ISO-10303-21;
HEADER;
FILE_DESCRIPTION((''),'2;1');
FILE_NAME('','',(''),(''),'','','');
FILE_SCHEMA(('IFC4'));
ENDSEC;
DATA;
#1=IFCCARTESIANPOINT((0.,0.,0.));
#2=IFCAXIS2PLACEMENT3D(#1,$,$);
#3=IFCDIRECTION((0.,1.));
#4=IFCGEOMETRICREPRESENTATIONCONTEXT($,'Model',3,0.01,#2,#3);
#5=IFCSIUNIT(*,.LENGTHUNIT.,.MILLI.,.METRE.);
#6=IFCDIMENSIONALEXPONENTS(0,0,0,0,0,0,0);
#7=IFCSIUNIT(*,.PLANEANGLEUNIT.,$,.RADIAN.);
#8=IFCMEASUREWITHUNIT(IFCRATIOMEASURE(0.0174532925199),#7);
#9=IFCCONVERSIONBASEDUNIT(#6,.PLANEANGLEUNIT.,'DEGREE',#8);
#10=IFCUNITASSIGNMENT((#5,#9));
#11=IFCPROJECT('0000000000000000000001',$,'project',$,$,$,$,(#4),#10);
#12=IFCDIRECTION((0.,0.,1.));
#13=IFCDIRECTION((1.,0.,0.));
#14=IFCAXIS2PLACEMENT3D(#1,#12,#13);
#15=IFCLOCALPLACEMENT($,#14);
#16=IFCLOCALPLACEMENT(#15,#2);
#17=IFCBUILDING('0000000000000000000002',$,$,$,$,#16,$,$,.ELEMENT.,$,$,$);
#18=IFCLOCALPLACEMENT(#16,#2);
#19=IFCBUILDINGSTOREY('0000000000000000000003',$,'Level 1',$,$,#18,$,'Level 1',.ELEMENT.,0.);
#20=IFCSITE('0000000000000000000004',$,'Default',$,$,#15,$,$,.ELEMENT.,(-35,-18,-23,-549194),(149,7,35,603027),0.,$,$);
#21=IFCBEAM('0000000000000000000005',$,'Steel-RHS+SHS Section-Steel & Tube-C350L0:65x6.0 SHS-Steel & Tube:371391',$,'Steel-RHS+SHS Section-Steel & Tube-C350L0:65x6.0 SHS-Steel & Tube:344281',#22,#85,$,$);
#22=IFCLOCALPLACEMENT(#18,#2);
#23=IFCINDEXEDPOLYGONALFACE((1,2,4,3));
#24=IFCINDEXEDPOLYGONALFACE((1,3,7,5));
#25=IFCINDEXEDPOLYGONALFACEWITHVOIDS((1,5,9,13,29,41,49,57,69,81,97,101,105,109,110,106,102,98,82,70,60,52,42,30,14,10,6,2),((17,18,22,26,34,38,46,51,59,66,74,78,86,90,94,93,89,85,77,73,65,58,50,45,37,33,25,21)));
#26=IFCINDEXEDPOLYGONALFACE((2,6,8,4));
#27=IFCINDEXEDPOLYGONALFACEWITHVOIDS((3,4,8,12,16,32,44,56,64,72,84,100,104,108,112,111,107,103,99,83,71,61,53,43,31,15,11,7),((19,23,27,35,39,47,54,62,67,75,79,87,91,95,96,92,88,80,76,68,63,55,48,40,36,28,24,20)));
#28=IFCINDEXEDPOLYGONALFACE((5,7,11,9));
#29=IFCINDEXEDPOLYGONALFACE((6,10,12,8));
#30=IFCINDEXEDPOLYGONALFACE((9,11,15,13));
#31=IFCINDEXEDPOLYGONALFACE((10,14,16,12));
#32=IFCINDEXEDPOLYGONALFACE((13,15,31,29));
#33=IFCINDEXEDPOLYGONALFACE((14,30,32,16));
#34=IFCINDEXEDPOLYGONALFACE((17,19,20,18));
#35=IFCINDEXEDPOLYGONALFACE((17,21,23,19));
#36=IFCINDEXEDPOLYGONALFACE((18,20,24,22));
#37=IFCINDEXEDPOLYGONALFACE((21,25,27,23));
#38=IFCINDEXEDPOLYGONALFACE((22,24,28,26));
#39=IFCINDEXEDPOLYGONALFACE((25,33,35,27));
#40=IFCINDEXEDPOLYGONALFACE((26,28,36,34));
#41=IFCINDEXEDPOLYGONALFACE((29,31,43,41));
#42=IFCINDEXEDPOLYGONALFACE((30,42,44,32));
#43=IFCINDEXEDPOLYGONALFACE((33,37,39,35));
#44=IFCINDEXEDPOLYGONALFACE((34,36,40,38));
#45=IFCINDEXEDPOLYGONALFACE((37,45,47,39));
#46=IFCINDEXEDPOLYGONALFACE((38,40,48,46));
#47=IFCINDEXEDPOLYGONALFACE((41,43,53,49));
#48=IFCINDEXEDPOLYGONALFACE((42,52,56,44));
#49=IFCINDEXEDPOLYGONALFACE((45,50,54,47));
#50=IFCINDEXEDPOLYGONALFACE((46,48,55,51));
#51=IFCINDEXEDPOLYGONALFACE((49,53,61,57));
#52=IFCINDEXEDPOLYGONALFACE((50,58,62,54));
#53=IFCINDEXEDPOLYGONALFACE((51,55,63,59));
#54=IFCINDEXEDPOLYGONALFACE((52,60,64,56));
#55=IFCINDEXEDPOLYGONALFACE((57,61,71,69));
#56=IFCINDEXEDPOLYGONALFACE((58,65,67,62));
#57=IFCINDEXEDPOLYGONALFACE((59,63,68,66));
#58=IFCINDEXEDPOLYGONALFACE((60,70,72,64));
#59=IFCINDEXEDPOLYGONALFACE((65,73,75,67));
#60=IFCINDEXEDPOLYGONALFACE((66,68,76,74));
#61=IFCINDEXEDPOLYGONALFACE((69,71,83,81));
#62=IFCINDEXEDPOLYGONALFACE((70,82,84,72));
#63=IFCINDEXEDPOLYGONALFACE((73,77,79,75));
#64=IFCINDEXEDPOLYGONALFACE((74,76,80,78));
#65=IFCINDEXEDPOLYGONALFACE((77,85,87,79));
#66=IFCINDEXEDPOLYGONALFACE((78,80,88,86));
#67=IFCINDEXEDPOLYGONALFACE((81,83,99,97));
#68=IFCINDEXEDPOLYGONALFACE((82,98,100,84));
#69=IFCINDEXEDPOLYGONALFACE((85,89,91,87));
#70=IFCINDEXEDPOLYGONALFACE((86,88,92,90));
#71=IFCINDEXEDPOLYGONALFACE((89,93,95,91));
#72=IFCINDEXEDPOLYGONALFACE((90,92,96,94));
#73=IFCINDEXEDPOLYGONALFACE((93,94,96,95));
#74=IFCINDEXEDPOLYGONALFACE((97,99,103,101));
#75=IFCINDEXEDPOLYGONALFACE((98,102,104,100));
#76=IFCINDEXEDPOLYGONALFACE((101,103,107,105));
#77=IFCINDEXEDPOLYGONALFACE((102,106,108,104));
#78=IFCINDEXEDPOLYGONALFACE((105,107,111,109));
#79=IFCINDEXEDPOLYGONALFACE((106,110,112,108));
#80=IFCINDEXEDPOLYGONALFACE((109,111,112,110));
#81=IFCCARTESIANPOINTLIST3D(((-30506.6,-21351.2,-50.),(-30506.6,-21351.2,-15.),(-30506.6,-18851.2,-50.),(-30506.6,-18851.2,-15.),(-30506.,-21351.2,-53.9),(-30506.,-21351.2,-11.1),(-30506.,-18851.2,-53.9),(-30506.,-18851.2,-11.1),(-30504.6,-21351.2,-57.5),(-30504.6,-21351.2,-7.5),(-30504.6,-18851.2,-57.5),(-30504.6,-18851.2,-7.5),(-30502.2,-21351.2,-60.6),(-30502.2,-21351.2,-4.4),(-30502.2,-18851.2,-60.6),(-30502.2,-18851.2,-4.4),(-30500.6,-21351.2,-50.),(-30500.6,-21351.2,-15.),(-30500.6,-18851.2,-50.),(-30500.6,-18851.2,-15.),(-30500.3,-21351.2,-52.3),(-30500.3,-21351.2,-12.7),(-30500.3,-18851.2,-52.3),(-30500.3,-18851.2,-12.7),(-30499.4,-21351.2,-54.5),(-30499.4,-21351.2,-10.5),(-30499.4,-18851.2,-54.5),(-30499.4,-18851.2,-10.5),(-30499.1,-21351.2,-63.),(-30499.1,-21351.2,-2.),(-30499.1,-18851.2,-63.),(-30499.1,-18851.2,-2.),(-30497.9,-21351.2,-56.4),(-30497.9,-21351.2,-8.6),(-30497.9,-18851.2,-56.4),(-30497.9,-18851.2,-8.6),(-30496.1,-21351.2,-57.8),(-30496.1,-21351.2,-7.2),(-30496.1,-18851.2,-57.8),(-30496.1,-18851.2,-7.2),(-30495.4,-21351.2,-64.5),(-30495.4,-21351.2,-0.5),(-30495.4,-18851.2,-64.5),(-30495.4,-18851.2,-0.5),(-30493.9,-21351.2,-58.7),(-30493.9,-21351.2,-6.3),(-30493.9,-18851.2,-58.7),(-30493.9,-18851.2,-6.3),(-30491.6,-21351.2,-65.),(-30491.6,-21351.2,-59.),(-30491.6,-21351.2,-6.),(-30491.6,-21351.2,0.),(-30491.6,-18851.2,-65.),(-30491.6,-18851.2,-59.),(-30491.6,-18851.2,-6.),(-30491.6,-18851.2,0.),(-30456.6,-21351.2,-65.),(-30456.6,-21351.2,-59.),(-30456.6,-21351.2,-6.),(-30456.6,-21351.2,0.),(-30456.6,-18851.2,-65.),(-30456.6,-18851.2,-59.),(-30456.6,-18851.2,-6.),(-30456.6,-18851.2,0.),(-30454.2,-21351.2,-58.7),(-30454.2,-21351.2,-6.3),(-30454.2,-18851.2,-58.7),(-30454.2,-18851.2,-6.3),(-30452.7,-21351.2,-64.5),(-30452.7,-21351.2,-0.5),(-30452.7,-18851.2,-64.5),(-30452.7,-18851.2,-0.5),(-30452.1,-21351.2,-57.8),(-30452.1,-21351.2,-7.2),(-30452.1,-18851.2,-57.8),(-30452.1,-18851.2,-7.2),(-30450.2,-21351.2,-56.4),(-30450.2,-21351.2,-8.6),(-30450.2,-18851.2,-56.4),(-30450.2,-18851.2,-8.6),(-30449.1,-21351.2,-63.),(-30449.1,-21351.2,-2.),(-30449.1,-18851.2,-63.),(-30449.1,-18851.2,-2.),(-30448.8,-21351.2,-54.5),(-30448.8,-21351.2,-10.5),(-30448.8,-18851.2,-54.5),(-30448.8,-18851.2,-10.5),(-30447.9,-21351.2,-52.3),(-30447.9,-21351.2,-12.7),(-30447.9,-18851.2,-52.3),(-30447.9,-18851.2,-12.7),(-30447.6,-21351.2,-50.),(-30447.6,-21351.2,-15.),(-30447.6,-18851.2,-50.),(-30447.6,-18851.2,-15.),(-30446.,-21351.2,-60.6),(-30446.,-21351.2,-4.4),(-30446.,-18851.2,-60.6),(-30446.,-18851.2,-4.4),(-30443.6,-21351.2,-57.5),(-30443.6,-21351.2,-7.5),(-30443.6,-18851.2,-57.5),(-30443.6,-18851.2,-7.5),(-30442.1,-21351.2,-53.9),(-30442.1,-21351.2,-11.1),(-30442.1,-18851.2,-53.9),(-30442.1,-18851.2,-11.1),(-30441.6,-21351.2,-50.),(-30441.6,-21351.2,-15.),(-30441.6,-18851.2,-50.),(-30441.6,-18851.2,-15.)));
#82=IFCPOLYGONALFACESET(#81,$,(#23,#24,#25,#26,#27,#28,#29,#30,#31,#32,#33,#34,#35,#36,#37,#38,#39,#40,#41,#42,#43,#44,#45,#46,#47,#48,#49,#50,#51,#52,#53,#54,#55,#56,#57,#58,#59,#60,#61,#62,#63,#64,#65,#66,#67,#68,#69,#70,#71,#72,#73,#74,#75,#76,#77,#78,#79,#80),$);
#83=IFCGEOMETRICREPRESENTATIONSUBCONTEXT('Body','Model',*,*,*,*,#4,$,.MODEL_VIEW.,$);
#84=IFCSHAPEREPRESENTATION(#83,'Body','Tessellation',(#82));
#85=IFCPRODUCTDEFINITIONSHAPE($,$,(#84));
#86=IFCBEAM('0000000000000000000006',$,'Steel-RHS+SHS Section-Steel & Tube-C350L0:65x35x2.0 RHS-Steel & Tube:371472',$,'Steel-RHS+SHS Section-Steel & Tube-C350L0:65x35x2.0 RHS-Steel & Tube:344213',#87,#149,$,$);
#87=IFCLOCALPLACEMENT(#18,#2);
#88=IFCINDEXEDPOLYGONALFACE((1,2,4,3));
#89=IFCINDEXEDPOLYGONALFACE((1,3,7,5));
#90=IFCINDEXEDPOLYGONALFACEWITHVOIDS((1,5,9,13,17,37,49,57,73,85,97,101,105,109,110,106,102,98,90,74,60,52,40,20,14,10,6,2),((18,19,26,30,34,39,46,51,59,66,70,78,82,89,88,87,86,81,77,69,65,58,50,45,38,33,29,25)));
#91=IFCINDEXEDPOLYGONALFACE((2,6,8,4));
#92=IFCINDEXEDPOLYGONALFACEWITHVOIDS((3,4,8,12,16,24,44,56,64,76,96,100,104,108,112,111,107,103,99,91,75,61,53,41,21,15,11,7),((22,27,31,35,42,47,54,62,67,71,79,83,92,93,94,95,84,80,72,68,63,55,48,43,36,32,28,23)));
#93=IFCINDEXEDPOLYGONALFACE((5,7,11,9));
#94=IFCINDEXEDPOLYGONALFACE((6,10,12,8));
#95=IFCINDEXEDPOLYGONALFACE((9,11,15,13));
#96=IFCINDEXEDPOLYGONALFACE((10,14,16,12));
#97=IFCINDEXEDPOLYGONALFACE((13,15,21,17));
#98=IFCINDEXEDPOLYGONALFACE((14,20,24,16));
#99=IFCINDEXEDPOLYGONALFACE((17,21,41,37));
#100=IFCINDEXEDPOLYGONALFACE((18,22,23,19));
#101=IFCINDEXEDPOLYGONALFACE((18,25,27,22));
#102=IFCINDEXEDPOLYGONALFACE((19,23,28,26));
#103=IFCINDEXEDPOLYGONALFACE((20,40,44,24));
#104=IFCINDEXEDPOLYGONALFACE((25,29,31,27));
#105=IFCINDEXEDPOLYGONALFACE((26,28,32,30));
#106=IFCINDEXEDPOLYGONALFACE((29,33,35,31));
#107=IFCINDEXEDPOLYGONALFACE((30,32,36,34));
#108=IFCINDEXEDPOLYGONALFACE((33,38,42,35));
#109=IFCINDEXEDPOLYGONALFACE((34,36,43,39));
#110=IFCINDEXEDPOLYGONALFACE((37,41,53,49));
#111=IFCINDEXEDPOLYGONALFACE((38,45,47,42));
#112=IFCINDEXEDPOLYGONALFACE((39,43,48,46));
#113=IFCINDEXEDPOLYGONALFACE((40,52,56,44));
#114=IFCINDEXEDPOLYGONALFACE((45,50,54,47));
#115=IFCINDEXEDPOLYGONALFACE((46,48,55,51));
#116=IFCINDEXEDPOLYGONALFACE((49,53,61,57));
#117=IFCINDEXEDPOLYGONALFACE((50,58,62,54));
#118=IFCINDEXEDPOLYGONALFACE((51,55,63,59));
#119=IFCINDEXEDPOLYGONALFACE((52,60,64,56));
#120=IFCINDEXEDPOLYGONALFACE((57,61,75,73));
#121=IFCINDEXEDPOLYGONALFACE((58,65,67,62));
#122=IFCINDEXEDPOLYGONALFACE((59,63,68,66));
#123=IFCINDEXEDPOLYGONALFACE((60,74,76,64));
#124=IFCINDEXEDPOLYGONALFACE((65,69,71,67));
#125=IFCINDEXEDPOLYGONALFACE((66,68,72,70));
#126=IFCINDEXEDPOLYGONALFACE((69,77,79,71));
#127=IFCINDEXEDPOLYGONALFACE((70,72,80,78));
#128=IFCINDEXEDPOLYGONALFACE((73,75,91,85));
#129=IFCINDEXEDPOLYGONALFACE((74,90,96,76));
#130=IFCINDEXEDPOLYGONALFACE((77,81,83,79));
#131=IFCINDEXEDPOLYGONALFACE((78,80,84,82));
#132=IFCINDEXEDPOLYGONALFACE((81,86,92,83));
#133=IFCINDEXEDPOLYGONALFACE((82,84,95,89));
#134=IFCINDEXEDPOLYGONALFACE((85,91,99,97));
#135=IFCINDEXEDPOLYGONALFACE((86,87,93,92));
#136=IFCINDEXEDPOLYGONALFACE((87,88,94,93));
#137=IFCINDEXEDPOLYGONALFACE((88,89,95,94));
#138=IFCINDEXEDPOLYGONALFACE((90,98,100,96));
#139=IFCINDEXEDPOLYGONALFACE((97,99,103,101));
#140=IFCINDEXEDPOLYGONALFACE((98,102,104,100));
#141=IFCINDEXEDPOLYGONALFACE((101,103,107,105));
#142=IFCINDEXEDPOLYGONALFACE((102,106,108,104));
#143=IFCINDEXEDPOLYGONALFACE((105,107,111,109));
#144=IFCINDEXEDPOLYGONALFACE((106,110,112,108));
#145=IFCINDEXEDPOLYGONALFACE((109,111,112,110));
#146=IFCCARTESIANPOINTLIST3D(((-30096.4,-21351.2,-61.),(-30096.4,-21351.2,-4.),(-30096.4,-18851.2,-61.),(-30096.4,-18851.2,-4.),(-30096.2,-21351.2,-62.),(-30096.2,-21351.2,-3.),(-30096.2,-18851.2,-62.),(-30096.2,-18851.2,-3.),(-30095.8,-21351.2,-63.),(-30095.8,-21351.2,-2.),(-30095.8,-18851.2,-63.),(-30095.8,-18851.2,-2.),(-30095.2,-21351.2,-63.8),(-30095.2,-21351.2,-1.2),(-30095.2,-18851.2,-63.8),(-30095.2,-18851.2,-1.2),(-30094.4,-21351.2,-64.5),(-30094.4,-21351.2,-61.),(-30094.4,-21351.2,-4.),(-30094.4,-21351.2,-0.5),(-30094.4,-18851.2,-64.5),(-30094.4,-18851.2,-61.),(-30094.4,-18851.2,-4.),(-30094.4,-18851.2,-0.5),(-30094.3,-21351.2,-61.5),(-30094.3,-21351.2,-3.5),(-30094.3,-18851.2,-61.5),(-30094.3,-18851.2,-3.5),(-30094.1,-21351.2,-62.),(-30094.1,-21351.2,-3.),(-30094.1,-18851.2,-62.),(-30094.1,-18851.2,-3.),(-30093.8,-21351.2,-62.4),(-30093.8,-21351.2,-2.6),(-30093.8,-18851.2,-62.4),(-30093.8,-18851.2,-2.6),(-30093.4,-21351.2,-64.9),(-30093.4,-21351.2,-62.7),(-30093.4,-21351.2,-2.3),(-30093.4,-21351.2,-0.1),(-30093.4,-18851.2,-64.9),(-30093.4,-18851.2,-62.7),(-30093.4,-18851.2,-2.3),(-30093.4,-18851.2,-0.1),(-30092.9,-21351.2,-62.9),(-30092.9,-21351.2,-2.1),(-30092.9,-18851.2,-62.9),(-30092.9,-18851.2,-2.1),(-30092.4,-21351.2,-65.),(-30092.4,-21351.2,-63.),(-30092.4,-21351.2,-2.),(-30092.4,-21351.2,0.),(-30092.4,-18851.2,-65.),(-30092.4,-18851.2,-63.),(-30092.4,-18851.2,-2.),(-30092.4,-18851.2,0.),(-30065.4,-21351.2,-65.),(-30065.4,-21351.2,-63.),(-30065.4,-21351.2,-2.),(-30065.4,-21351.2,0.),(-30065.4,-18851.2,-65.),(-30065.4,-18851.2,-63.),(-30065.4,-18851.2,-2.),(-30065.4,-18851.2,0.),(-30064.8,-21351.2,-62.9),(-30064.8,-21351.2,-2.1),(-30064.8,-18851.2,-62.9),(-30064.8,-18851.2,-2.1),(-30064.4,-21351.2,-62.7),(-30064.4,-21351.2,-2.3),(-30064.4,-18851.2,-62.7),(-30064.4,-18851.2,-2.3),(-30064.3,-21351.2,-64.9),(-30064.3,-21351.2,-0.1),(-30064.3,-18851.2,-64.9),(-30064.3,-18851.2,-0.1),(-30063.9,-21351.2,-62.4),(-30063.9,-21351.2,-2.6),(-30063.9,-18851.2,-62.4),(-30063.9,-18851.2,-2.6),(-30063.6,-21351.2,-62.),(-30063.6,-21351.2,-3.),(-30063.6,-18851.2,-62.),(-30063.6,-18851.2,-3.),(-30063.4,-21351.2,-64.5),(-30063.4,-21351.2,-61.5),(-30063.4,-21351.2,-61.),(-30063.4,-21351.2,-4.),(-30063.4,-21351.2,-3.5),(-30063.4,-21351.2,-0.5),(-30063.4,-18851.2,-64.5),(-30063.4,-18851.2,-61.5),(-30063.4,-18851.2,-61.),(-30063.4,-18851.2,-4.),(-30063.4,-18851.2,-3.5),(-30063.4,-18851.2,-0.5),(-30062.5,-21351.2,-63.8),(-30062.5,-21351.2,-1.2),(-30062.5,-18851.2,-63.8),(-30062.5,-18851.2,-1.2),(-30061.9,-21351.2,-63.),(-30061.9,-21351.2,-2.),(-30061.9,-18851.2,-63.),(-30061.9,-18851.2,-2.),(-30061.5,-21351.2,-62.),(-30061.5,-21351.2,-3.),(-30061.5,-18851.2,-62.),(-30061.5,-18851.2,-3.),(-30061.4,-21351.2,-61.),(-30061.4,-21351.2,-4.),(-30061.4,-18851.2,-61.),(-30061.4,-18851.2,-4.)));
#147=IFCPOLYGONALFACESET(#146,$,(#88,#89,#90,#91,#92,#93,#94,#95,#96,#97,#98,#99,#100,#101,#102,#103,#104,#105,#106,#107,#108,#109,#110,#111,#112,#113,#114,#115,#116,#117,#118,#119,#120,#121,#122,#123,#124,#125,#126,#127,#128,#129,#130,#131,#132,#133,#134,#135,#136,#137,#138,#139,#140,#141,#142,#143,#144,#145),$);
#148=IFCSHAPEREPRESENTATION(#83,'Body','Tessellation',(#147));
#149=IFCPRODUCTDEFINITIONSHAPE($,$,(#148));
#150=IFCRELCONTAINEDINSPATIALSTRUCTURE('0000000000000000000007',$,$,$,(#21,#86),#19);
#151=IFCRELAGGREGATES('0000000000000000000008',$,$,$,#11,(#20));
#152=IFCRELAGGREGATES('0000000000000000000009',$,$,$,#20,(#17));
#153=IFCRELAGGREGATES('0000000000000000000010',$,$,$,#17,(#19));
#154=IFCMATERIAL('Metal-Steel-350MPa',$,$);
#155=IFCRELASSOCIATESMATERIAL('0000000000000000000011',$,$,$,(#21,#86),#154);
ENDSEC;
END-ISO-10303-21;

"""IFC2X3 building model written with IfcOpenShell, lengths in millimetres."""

from ifc_helpers import new_model, entity, si_unit, converted_unit, direction, frame, frame_2d, origin, origin_with_axes, place, context, subcontext, project, spatial, polyline, circle_curve, parameter, trimmed, segment, composite_curve, outline, extrude, material, element, save


model = new_model("IFC2X3")

# Units and contexts
model_context = context("Model", 3, precision=0.01, world=origin(), true_north=direction((0.0, 1.0)))
body_context = subcontext(model_context, "Body", "Model", "MODEL_VIEW")
ifc_project = project(units=[si_unit("LENGTHUNIT", "METRE", prefix="MILLI"), converted_unit("PLANEANGLEUNIT", "DEGREE", entity("IfcRatioMeasure", 0.0174532925199), si_unit("PLANEANGLEUNIT", "RADIAN"), dimensions=[0, 0, 0, 0, 0, 0, 0])], contexts=[model_context])

# Site, building, storey
site_placement = place(None, origin_with_axes())
site = spatial("IfcSite", under=ifc_project, at=site_placement, Name="Default", CompositionType="ELEMENT", RefLatitude=(-35, -18, -23, -549194), RefLongitude=(149, 7, 35, 603027), RefElevation=0.0)
building_placement = place(site_placement, origin())
building = spatial("IfcBuilding", under=site, at=building_placement, CompositionType="ELEMENT")
storey_placement = place(building_placement, origin())
storey = spatial("IfcBuildingStorey", under=building, at=storey_placement, Name="Level 1", LongName="Level 1", CompositionType="ELEMENT", Elevation=0.0)

# Beams
ifc_material = material(Name="Metal-Steel-350MPa")
beam_1_placement = place(storey_placement, frame((-30474.1, -18851.2, 0.0), z_axis=(0.0, 0.0, 1.0), x_axis=(0.0, -1.0, 0.0)))
element("IfcBeam", 1, at=beam_1_placement, inside=storey, material=ifc_material, Name="Steel-RHS+SHS Section-Steel & Tube-C350L0:65x6.0 SHS-Steel & Tube:371391", ObjectType="Steel-RHS+SHS Section-Steel & Tube-C350L0:65x6.0 SHS-Steel & Tube:344281", context=body_context, shape_type="SweptSolid", body=[
    extrude(outline(composite_curve([segment(trimmed(circle_curve(frame_2d((-17.5, -17.5), x_axis=(1.0, 0.0)), 15.0), [parameter(180.0)], [parameter(270.0)], True, "PARAMETER"), True, "CONTINUOUS"), segment(polyline([(-17.5, -32.5), (17.5, -32.5)]), True, "CONTINUOUS"), segment(trimmed(circle_curve(frame_2d((17.5, -17.5), x_axis=(1.0, 0.0)), 15.0), [parameter(270.0)], [parameter(0.0)], True, "PARAMETER"), True, "CONTINUOUS"), segment(polyline([(32.5, -17.5), (32.5, 17.5)]), True, "CONTINUOUS"), segment(trimmed(circle_curve(frame_2d((17.5, 17.5), x_axis=(1.0, 0.0)), 15.0), [parameter(0.0)], [parameter(90.0)], True, "PARAMETER"), True, "CONTINUOUS"), segment(polyline([(17.5, 32.5), (-17.5, 32.5)]), True, "CONTINUOUS"), segment(trimmed(circle_curve(frame_2d((-17.5, 17.5), x_axis=(1.0, 0.0)), 15.0), [parameter(90.0)], [parameter(180.0)], True, "PARAMETER"), True, "CONTINUOUS"), segment(polyline([(-32.5, 17.5), (-32.5, -17.5)]), True, "CONTINUOUS")], self_intersect=False), holes=[composite_curve([segment(polyline([(17.5, -26.5), (-17.5, -26.5)]), True, "CONTINUOUS"), segment(trimmed(circle_curve(frame_2d((-17.5, -17.5), x_axis=(1.0, 0.0)), 9.0), [parameter(180.0)], [parameter(270.0)], True, "PARAMETER"), False, "CONTINUOUS"), segment(polyline([(-26.5, -17.5), (-26.5, 17.5)]), True, "CONTINUOUS"), segment(trimmed(circle_curve(frame_2d((-17.5, 17.5), x_axis=(1.0, 0.0)), 9.0), [parameter(90.0)], [parameter(180.0)], True, "PARAMETER"), False, "CONTINUOUS"), segment(polyline([(-17.5, 26.5), (17.5, 26.5)]), True, "CONTINUOUS"), segment(trimmed(circle_curve(frame_2d((17.5, 17.5), x_axis=(1.0, 0.0)), 9.0), [parameter(360.0)], [parameter(90.0)], True, "PARAMETER"), False, "CONTINUOUS"), segment(polyline([(26.5, 17.5), (26.5, -17.5)]), True, "CONTINUOUS"), segment(trimmed(circle_curve(frame_2d((17.5, -17.5), x_axis=(1.0, 0.0)), 9.0), [parameter(270.0)], [parameter(0.0)], True, "PARAMETER"), False, "CONTINUOUS")], self_intersect=False)]), frame((0.0, 0.0, -32.5), z_axis=(1.0, 0.0, 0.0), x_axis=(0.0, -1.0, 0.0)), (0.0, 0.0, 1.0), 2500.0),
])
beam_2_placement = place(storey_placement, frame((-30078.9, -18851.2, 0.0), z_axis=(0.0, 0.0, 1.0), x_axis=(0.0, -1.0, 0.0)))
element("IfcBeam", 2, at=beam_2_placement, inside=storey, material=ifc_material, Name="Steel-RHS+SHS Section-Steel & Tube-C350L0:65x35x2.0 RHS-Steel & Tube:371472", ObjectType="Steel-RHS+SHS Section-Steel & Tube-C350L0:65x35x2.0 RHS-Steel & Tube:344213", context=body_context, shape_type="SweptSolid", body=[
    extrude(outline(composite_curve([segment(trimmed(circle_curve(frame_2d((-13.5, -28.5), x_axis=(1.0, 0.0)), 4.0), [parameter(180.0)], [parameter(270.0)], True, "PARAMETER"), True, "CONTINUOUS"), segment(polyline([(-13.5, -32.5), (13.5, -32.5)]), True, "CONTINUOUS"), segment(trimmed(circle_curve(frame_2d((13.5, -28.5), x_axis=(1.0, 0.0)), 4.0), [parameter(270.0)], [parameter(0.0)], True, "PARAMETER"), True, "CONTINUOUS"), segment(polyline([(17.5, -28.5), (17.5, 28.5)]), True, "CONTINUOUS"), segment(trimmed(circle_curve(frame_2d((13.5, 28.5), x_axis=(1.0, 0.0)), 4.0), [parameter(0.0)], [parameter(90.0)], True, "PARAMETER"), True, "CONTINUOUS"), segment(polyline([(13.5, 32.5), (-13.5, 32.5)]), True, "CONTINUOUS"), segment(trimmed(circle_curve(frame_2d((-13.5, 28.5), x_axis=(1.0, 0.0)), 4.0), [parameter(90.0)], [parameter(180.0)], True, "PARAMETER"), True, "CONTINUOUS"), segment(polyline([(-17.5, 28.5), (-17.5, -28.5)]), True, "CONTINUOUS")], self_intersect=False), holes=[composite_curve([segment(polyline([(13.5, -30.5), (-13.5, -30.5)]), True, "CONTINUOUS"), segment(trimmed(circle_curve(frame_2d((-13.5, -28.5), x_axis=(1.0, 0.0)), 2.0), [parameter(180.0)], [parameter(270.0)], True, "PARAMETER"), False, "CONTINUOUS"), segment(polyline([(-15.5, -28.5), (-15.5, 28.5)]), True, "CONTINUOUS"), segment(trimmed(circle_curve(frame_2d((-13.5, 28.5), x_axis=(1.0, 0.0)), 2.0), [parameter(90.0)], [parameter(180.0)], True, "PARAMETER"), False, "CONTINUOUS"), segment(polyline([(-13.5, 30.5), (13.5, 30.5)]), True, "CONTINUOUS"), segment(trimmed(circle_curve(frame_2d((13.5, 28.5), x_axis=(1.0, 0.0)), 2.0), [parameter(360.0)], [parameter(90.0)], True, "PARAMETER"), False, "CONTINUOUS"), segment(polyline([(15.5, 28.5), (15.5, -28.5)]), True, "CONTINUOUS"), segment(trimmed(circle_curve(frame_2d((13.5, -28.5), x_axis=(1.0, 0.0)), 2.0), [parameter(270.0)], [parameter(0.0)], True, "PARAMETER"), False, "CONTINUOUS")], self_intersect=False)]), frame((0.0, 0.0, -32.5), z_axis=(1.0, 0.0, 0.0), x_axis=(0.0, -1.0, 0.0)), (0.0, 0.0, 1.0), 2500.0),
])

save(model, "model.ifc")
